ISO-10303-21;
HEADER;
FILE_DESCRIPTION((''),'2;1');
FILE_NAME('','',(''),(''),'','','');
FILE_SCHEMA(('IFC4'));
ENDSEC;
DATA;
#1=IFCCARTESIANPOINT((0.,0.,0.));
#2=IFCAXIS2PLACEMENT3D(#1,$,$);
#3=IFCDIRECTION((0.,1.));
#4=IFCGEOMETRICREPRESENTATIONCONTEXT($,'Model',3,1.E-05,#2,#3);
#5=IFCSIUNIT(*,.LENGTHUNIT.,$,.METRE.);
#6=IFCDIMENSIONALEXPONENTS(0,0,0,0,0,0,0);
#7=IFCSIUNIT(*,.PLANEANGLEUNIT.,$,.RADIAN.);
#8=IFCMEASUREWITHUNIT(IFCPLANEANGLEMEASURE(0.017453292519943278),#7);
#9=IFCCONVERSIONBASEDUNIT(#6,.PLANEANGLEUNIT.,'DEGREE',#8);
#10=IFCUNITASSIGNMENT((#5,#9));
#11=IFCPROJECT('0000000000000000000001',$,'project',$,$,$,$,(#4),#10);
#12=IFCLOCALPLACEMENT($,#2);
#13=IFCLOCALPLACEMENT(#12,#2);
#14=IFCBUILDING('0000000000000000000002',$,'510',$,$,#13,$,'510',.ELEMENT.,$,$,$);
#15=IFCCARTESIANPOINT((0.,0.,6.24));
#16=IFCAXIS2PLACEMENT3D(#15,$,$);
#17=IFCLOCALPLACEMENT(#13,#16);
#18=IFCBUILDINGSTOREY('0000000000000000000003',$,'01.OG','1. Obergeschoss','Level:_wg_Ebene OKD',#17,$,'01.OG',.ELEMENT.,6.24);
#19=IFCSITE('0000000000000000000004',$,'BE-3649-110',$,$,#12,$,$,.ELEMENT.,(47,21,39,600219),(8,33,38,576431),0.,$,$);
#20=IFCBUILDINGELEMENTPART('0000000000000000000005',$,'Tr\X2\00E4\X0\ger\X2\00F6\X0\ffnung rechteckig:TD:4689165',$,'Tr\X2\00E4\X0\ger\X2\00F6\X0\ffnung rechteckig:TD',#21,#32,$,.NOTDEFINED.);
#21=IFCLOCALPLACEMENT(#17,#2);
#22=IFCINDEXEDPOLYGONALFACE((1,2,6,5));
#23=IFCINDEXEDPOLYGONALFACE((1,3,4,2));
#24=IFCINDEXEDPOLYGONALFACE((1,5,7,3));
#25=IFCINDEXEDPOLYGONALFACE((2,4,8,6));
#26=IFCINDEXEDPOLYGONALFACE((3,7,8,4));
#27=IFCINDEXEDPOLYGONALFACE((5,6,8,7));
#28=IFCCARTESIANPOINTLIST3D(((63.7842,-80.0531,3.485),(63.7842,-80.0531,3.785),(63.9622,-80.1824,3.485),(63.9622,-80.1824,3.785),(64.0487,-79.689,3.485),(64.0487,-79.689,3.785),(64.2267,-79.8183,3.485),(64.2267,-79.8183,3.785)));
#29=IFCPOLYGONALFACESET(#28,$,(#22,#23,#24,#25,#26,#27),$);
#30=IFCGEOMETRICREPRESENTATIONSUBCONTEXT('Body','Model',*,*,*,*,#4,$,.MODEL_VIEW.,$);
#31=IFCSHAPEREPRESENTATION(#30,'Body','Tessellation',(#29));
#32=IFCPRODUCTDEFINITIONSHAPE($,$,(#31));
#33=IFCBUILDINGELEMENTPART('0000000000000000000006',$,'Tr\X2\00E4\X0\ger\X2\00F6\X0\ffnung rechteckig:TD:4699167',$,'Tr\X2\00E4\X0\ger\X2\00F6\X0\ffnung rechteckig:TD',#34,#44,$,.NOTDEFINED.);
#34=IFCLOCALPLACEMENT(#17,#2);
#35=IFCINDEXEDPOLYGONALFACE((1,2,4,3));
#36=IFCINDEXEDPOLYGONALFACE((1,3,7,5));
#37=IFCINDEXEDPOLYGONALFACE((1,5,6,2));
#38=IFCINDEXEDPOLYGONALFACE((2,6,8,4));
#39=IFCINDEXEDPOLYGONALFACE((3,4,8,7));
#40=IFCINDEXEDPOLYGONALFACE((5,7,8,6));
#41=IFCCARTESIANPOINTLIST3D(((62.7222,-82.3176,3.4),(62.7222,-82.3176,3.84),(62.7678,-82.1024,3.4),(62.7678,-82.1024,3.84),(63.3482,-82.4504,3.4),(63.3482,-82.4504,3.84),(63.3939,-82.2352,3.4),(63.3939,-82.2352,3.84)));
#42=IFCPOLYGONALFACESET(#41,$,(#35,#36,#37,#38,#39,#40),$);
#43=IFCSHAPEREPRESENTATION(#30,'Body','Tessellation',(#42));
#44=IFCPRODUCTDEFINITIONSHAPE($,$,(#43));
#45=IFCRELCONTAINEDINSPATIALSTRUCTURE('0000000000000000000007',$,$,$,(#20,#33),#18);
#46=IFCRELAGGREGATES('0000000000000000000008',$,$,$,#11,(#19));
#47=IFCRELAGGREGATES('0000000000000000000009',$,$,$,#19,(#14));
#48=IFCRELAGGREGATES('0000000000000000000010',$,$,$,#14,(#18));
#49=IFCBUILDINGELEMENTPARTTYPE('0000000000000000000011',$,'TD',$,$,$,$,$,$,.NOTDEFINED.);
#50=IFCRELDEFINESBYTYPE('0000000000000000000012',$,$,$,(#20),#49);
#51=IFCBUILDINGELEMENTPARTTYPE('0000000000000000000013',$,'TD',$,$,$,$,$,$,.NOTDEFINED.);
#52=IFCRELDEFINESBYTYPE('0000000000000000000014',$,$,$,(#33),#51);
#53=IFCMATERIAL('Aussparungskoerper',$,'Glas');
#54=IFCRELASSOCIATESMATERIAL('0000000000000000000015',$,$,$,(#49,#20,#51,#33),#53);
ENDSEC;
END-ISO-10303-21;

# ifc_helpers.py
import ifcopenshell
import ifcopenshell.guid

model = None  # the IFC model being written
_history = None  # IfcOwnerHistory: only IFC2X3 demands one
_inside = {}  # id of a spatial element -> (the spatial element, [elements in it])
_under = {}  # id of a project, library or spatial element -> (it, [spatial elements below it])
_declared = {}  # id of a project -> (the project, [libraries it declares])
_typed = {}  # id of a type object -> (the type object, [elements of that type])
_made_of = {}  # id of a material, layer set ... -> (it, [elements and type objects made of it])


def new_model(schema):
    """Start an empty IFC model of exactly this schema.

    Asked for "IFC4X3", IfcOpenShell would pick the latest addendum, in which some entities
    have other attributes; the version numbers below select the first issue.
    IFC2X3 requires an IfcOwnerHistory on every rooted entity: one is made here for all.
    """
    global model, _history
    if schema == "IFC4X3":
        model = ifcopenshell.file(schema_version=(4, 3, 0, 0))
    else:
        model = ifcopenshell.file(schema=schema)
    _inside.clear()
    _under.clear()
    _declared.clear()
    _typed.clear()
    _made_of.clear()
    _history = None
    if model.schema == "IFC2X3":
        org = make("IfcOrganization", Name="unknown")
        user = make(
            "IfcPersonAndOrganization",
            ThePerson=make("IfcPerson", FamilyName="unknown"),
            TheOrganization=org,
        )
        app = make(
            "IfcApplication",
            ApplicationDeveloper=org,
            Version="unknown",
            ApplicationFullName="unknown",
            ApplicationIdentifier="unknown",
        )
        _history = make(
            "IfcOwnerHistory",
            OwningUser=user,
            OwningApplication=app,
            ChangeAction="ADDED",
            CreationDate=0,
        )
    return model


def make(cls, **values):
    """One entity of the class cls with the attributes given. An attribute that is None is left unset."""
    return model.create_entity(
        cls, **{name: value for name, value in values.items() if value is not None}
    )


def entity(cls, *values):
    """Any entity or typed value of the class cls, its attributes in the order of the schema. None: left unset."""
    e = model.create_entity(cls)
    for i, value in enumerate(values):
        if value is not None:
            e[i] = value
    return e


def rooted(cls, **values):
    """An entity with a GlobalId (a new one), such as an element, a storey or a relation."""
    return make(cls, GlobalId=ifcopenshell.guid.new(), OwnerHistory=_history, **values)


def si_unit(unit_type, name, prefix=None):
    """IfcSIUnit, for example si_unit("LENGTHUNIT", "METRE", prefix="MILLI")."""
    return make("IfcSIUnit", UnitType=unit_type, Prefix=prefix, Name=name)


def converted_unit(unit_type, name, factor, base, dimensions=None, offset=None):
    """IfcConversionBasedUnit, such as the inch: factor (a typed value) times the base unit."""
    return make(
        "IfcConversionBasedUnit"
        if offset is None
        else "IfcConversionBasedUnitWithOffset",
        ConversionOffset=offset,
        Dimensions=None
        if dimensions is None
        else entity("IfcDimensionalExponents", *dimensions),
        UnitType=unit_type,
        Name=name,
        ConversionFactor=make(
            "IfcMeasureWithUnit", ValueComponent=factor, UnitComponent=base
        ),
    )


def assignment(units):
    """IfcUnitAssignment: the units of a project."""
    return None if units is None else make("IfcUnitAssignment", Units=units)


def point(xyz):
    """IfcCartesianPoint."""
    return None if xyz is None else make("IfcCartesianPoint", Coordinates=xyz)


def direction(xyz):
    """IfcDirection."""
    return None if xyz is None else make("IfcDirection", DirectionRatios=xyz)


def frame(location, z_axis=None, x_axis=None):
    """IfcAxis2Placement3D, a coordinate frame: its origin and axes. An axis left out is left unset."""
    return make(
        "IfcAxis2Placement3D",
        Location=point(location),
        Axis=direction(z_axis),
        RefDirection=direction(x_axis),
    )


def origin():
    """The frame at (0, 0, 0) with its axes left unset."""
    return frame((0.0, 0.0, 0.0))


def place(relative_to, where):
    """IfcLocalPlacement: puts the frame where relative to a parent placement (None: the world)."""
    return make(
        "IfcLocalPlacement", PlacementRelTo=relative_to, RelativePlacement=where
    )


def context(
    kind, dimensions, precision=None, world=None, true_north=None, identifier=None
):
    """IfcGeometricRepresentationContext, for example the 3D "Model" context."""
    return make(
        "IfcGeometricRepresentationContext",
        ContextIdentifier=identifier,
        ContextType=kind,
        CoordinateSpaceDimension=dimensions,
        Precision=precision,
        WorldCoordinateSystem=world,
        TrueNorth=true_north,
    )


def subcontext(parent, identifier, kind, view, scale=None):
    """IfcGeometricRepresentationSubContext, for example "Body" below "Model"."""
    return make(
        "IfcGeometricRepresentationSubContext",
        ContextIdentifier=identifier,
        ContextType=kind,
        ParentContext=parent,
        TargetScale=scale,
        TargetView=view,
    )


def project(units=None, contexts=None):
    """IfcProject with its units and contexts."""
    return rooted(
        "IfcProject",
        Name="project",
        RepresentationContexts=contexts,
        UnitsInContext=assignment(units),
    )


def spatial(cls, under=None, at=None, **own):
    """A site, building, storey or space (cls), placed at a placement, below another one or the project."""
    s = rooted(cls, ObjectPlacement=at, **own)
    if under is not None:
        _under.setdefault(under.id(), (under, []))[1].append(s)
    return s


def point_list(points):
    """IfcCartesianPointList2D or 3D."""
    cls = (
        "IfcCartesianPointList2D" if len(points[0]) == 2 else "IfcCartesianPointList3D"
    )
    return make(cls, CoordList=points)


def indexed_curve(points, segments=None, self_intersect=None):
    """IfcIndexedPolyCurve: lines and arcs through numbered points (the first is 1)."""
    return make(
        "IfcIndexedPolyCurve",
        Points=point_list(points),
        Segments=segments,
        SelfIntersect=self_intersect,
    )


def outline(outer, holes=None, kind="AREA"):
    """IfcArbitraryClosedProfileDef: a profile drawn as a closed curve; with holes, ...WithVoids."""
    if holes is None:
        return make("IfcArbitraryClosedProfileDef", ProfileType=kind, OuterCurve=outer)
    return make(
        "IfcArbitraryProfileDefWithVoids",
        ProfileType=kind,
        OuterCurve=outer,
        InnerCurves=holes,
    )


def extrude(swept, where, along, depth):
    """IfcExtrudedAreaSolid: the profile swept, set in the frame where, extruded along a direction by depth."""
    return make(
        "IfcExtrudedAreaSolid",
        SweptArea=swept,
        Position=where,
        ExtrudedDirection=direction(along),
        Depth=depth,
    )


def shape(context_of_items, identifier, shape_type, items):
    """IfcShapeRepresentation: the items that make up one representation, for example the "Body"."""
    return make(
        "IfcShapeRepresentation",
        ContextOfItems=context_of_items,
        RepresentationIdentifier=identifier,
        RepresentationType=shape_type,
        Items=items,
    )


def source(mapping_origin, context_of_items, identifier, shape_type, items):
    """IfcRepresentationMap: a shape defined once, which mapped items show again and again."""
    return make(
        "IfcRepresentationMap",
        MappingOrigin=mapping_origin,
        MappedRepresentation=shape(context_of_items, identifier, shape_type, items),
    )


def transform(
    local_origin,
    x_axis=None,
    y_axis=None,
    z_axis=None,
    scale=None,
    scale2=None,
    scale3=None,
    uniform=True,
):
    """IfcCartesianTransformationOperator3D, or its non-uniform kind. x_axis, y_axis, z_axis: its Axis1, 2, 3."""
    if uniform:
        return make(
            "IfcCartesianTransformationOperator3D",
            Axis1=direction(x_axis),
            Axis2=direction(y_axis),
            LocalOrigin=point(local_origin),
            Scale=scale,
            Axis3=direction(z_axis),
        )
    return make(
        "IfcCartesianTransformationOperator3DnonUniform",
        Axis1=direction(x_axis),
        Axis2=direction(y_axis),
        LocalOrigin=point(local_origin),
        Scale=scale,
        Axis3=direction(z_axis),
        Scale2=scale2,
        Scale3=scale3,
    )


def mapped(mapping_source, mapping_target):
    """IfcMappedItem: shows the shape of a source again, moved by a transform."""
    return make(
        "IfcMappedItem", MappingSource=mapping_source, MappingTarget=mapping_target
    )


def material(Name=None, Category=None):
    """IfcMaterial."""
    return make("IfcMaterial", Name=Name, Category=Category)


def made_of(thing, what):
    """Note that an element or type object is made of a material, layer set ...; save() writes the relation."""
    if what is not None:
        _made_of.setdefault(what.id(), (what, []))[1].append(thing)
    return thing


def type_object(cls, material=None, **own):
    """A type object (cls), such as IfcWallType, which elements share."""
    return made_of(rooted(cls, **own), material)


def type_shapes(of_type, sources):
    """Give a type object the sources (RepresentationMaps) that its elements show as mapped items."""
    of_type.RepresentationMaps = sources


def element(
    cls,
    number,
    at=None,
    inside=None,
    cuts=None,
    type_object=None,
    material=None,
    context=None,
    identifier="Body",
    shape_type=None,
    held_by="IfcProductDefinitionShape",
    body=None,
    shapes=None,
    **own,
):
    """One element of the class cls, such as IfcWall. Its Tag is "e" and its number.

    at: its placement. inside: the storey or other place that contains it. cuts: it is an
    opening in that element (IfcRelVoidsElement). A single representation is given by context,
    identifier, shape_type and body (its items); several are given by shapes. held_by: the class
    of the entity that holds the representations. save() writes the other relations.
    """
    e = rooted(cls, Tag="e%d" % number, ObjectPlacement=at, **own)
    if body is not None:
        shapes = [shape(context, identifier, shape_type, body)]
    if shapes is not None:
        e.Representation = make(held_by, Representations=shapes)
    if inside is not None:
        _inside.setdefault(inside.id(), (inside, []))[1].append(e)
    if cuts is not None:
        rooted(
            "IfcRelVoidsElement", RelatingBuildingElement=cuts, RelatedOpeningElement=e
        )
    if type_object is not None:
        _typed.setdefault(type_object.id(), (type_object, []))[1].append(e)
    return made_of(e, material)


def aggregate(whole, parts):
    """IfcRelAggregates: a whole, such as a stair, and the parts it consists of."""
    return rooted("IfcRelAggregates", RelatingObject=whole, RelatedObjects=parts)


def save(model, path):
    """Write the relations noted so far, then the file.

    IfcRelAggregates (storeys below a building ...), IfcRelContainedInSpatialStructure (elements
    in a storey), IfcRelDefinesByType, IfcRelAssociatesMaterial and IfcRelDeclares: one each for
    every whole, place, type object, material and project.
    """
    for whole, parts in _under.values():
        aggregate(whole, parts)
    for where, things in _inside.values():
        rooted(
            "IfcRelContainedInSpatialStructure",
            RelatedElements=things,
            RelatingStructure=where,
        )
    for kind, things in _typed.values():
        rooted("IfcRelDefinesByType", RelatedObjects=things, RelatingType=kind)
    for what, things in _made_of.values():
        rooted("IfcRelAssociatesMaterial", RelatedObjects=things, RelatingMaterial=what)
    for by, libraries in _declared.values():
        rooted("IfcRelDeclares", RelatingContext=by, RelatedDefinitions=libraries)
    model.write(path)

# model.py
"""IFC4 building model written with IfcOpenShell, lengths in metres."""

from ifc_helpers import new_model, entity, si_unit, converted_unit, direction, frame, origin, place, context, subcontext, project, spatial, indexed_curve, outline, extrude, source, transform, mapped, material, type_object, type_shapes, element, save


model = new_model("IFC4")

# Units and contexts
model_context = context("Model", 3, precision=1e-05, world=origin(), true_north=direction((0.0, 1.0)))
body_context = subcontext(model_context, "Body", "Model", "MODEL_VIEW")
ifc_project = project(units=[si_unit("LENGTHUNIT", "METRE"), converted_unit("PLANEANGLEUNIT", "DEGREE", entity("IfcPlaneAngleMeasure", 0.017453292519943278), si_unit("PLANEANGLEUNIT", "RADIAN"), dimensions=[0, 0, 0, 0, 0, 0, 0])], contexts=[model_context])

# Site, building, storey
site_placement = place(None, origin())
site = spatial("IfcSite", under=ifc_project, at=site_placement, Name="BE-3649-110", CompositionType="ELEMENT", RefLatitude=(47, 21, 39, 600219), RefLongitude=(8, 33, 38, 576431), RefElevation=0.0)
building_placement = place(site_placement, origin())
building = spatial("IfcBuilding", under=site, at=building_placement, Name="510", LongName="510", CompositionType="ELEMENT")
storey_placement = place(building_placement, frame((0.0, 0.0, 6.24)))
storey = spatial("IfcBuildingStorey", under=building, at=storey_placement, Name="01.OG", Description="1. Obergeschoss", ObjectType="Level:_wg_Ebene OKD", LongName="01.OG", CompositionType="ELEMENT", Elevation=6.24)

# Building element parts
ifc_material_1 = material(Name="Aussparungskoerper", Category="Glas")
building_element_part_type_1 = type_object("IfcBuildingElementPartType", Name="TD", PredefinedType="NOTDEFINED", material=ifc_material_1)
shared_shape_1 = source(origin(), body_context, "Body", "SweptSolid", [
    extrude(outline(indexed_curve([(-0.225, -0.15), (0.225, -0.15), (0.225, 0.15), (-0.225, 0.15), (-0.225, -0.15)], self_intersect=False)), frame((0.0, 0.0, -0.22), z_axis=(0.0, 0.0, 1.0), x_axis=(-1.0, 0.0, 0.0)), (0.0, 0.0, 1.0), 0.22),
])
type_shapes(building_element_part_type_1, [shared_shape_1])
for number, where, z_axis, x_axis, name in (
    (1, (64.0944, -80.0003, 3.635), (0.809017, -0.587785, 0.0), (-0.587785, -0.809017, 0.0), "Trägeröffnung rechteckig:TD:4689165"),
):
    element("IfcBuildingElementPart", number, at=place(storey_placement, frame(where, z_axis=z_axis, x_axis=x_axis)), inside=storey, type_object=building_element_part_type_1, material=ifc_material_1, Name=name, ObjectType="Trägeröffnung rechteckig:TD", PredefinedType="NOTDEFINED", context=body_context, shape_type="MappedRepresentation", body=[
        mapped(shared_shape_1, transform((0.0, 0.0, 0.0), scale=1.0)),
    ])
building_element_part_type_2 = type_object("IfcBuildingElementPartType", Name="TD", PredefinedType="NOTDEFINED", material=ifc_material_1)
shared_shape_2 = source(origin(), body_context, "Body", "SweptSolid", [
    extrude(outline(indexed_curve([(-0.22, -0.32), (0.22, -0.32), (0.22, 0.32), (-0.22, 0.32), (-0.22, -0.32)], self_intersect=False)), frame((0.0, 0.0, -0.22), z_axis=(0.0, 0.0, 1.0), x_axis=(0.0, 1.0, 0.0)), (0.0, 0.0, 1.0), 0.22),
])
type_shapes(building_element_part_type_2, [shared_shape_2])
building_element_part_placement = place(storey_placement, frame((63.0352, -82.384, 3.62), z_axis=(-0.207566, -0.978221, 0.0), x_axis=(0.978221, -0.207566, 0.0)))
element("IfcBuildingElementPart", 2, at=building_element_part_placement, inside=storey, type_object=building_element_part_type_2, material=ifc_material_1, Name="Trägeröffnung rechteckig:TD:4699167", ObjectType="Trägeröffnung rechteckig:TD", PredefinedType="NOTDEFINED", context=body_context, shape_type="MappedRepresentation", body=[
    mapped(shared_shape_2, transform((0.0, 0.0, 0.0), scale=1.0)),
])

save(model, "model.ifc")
